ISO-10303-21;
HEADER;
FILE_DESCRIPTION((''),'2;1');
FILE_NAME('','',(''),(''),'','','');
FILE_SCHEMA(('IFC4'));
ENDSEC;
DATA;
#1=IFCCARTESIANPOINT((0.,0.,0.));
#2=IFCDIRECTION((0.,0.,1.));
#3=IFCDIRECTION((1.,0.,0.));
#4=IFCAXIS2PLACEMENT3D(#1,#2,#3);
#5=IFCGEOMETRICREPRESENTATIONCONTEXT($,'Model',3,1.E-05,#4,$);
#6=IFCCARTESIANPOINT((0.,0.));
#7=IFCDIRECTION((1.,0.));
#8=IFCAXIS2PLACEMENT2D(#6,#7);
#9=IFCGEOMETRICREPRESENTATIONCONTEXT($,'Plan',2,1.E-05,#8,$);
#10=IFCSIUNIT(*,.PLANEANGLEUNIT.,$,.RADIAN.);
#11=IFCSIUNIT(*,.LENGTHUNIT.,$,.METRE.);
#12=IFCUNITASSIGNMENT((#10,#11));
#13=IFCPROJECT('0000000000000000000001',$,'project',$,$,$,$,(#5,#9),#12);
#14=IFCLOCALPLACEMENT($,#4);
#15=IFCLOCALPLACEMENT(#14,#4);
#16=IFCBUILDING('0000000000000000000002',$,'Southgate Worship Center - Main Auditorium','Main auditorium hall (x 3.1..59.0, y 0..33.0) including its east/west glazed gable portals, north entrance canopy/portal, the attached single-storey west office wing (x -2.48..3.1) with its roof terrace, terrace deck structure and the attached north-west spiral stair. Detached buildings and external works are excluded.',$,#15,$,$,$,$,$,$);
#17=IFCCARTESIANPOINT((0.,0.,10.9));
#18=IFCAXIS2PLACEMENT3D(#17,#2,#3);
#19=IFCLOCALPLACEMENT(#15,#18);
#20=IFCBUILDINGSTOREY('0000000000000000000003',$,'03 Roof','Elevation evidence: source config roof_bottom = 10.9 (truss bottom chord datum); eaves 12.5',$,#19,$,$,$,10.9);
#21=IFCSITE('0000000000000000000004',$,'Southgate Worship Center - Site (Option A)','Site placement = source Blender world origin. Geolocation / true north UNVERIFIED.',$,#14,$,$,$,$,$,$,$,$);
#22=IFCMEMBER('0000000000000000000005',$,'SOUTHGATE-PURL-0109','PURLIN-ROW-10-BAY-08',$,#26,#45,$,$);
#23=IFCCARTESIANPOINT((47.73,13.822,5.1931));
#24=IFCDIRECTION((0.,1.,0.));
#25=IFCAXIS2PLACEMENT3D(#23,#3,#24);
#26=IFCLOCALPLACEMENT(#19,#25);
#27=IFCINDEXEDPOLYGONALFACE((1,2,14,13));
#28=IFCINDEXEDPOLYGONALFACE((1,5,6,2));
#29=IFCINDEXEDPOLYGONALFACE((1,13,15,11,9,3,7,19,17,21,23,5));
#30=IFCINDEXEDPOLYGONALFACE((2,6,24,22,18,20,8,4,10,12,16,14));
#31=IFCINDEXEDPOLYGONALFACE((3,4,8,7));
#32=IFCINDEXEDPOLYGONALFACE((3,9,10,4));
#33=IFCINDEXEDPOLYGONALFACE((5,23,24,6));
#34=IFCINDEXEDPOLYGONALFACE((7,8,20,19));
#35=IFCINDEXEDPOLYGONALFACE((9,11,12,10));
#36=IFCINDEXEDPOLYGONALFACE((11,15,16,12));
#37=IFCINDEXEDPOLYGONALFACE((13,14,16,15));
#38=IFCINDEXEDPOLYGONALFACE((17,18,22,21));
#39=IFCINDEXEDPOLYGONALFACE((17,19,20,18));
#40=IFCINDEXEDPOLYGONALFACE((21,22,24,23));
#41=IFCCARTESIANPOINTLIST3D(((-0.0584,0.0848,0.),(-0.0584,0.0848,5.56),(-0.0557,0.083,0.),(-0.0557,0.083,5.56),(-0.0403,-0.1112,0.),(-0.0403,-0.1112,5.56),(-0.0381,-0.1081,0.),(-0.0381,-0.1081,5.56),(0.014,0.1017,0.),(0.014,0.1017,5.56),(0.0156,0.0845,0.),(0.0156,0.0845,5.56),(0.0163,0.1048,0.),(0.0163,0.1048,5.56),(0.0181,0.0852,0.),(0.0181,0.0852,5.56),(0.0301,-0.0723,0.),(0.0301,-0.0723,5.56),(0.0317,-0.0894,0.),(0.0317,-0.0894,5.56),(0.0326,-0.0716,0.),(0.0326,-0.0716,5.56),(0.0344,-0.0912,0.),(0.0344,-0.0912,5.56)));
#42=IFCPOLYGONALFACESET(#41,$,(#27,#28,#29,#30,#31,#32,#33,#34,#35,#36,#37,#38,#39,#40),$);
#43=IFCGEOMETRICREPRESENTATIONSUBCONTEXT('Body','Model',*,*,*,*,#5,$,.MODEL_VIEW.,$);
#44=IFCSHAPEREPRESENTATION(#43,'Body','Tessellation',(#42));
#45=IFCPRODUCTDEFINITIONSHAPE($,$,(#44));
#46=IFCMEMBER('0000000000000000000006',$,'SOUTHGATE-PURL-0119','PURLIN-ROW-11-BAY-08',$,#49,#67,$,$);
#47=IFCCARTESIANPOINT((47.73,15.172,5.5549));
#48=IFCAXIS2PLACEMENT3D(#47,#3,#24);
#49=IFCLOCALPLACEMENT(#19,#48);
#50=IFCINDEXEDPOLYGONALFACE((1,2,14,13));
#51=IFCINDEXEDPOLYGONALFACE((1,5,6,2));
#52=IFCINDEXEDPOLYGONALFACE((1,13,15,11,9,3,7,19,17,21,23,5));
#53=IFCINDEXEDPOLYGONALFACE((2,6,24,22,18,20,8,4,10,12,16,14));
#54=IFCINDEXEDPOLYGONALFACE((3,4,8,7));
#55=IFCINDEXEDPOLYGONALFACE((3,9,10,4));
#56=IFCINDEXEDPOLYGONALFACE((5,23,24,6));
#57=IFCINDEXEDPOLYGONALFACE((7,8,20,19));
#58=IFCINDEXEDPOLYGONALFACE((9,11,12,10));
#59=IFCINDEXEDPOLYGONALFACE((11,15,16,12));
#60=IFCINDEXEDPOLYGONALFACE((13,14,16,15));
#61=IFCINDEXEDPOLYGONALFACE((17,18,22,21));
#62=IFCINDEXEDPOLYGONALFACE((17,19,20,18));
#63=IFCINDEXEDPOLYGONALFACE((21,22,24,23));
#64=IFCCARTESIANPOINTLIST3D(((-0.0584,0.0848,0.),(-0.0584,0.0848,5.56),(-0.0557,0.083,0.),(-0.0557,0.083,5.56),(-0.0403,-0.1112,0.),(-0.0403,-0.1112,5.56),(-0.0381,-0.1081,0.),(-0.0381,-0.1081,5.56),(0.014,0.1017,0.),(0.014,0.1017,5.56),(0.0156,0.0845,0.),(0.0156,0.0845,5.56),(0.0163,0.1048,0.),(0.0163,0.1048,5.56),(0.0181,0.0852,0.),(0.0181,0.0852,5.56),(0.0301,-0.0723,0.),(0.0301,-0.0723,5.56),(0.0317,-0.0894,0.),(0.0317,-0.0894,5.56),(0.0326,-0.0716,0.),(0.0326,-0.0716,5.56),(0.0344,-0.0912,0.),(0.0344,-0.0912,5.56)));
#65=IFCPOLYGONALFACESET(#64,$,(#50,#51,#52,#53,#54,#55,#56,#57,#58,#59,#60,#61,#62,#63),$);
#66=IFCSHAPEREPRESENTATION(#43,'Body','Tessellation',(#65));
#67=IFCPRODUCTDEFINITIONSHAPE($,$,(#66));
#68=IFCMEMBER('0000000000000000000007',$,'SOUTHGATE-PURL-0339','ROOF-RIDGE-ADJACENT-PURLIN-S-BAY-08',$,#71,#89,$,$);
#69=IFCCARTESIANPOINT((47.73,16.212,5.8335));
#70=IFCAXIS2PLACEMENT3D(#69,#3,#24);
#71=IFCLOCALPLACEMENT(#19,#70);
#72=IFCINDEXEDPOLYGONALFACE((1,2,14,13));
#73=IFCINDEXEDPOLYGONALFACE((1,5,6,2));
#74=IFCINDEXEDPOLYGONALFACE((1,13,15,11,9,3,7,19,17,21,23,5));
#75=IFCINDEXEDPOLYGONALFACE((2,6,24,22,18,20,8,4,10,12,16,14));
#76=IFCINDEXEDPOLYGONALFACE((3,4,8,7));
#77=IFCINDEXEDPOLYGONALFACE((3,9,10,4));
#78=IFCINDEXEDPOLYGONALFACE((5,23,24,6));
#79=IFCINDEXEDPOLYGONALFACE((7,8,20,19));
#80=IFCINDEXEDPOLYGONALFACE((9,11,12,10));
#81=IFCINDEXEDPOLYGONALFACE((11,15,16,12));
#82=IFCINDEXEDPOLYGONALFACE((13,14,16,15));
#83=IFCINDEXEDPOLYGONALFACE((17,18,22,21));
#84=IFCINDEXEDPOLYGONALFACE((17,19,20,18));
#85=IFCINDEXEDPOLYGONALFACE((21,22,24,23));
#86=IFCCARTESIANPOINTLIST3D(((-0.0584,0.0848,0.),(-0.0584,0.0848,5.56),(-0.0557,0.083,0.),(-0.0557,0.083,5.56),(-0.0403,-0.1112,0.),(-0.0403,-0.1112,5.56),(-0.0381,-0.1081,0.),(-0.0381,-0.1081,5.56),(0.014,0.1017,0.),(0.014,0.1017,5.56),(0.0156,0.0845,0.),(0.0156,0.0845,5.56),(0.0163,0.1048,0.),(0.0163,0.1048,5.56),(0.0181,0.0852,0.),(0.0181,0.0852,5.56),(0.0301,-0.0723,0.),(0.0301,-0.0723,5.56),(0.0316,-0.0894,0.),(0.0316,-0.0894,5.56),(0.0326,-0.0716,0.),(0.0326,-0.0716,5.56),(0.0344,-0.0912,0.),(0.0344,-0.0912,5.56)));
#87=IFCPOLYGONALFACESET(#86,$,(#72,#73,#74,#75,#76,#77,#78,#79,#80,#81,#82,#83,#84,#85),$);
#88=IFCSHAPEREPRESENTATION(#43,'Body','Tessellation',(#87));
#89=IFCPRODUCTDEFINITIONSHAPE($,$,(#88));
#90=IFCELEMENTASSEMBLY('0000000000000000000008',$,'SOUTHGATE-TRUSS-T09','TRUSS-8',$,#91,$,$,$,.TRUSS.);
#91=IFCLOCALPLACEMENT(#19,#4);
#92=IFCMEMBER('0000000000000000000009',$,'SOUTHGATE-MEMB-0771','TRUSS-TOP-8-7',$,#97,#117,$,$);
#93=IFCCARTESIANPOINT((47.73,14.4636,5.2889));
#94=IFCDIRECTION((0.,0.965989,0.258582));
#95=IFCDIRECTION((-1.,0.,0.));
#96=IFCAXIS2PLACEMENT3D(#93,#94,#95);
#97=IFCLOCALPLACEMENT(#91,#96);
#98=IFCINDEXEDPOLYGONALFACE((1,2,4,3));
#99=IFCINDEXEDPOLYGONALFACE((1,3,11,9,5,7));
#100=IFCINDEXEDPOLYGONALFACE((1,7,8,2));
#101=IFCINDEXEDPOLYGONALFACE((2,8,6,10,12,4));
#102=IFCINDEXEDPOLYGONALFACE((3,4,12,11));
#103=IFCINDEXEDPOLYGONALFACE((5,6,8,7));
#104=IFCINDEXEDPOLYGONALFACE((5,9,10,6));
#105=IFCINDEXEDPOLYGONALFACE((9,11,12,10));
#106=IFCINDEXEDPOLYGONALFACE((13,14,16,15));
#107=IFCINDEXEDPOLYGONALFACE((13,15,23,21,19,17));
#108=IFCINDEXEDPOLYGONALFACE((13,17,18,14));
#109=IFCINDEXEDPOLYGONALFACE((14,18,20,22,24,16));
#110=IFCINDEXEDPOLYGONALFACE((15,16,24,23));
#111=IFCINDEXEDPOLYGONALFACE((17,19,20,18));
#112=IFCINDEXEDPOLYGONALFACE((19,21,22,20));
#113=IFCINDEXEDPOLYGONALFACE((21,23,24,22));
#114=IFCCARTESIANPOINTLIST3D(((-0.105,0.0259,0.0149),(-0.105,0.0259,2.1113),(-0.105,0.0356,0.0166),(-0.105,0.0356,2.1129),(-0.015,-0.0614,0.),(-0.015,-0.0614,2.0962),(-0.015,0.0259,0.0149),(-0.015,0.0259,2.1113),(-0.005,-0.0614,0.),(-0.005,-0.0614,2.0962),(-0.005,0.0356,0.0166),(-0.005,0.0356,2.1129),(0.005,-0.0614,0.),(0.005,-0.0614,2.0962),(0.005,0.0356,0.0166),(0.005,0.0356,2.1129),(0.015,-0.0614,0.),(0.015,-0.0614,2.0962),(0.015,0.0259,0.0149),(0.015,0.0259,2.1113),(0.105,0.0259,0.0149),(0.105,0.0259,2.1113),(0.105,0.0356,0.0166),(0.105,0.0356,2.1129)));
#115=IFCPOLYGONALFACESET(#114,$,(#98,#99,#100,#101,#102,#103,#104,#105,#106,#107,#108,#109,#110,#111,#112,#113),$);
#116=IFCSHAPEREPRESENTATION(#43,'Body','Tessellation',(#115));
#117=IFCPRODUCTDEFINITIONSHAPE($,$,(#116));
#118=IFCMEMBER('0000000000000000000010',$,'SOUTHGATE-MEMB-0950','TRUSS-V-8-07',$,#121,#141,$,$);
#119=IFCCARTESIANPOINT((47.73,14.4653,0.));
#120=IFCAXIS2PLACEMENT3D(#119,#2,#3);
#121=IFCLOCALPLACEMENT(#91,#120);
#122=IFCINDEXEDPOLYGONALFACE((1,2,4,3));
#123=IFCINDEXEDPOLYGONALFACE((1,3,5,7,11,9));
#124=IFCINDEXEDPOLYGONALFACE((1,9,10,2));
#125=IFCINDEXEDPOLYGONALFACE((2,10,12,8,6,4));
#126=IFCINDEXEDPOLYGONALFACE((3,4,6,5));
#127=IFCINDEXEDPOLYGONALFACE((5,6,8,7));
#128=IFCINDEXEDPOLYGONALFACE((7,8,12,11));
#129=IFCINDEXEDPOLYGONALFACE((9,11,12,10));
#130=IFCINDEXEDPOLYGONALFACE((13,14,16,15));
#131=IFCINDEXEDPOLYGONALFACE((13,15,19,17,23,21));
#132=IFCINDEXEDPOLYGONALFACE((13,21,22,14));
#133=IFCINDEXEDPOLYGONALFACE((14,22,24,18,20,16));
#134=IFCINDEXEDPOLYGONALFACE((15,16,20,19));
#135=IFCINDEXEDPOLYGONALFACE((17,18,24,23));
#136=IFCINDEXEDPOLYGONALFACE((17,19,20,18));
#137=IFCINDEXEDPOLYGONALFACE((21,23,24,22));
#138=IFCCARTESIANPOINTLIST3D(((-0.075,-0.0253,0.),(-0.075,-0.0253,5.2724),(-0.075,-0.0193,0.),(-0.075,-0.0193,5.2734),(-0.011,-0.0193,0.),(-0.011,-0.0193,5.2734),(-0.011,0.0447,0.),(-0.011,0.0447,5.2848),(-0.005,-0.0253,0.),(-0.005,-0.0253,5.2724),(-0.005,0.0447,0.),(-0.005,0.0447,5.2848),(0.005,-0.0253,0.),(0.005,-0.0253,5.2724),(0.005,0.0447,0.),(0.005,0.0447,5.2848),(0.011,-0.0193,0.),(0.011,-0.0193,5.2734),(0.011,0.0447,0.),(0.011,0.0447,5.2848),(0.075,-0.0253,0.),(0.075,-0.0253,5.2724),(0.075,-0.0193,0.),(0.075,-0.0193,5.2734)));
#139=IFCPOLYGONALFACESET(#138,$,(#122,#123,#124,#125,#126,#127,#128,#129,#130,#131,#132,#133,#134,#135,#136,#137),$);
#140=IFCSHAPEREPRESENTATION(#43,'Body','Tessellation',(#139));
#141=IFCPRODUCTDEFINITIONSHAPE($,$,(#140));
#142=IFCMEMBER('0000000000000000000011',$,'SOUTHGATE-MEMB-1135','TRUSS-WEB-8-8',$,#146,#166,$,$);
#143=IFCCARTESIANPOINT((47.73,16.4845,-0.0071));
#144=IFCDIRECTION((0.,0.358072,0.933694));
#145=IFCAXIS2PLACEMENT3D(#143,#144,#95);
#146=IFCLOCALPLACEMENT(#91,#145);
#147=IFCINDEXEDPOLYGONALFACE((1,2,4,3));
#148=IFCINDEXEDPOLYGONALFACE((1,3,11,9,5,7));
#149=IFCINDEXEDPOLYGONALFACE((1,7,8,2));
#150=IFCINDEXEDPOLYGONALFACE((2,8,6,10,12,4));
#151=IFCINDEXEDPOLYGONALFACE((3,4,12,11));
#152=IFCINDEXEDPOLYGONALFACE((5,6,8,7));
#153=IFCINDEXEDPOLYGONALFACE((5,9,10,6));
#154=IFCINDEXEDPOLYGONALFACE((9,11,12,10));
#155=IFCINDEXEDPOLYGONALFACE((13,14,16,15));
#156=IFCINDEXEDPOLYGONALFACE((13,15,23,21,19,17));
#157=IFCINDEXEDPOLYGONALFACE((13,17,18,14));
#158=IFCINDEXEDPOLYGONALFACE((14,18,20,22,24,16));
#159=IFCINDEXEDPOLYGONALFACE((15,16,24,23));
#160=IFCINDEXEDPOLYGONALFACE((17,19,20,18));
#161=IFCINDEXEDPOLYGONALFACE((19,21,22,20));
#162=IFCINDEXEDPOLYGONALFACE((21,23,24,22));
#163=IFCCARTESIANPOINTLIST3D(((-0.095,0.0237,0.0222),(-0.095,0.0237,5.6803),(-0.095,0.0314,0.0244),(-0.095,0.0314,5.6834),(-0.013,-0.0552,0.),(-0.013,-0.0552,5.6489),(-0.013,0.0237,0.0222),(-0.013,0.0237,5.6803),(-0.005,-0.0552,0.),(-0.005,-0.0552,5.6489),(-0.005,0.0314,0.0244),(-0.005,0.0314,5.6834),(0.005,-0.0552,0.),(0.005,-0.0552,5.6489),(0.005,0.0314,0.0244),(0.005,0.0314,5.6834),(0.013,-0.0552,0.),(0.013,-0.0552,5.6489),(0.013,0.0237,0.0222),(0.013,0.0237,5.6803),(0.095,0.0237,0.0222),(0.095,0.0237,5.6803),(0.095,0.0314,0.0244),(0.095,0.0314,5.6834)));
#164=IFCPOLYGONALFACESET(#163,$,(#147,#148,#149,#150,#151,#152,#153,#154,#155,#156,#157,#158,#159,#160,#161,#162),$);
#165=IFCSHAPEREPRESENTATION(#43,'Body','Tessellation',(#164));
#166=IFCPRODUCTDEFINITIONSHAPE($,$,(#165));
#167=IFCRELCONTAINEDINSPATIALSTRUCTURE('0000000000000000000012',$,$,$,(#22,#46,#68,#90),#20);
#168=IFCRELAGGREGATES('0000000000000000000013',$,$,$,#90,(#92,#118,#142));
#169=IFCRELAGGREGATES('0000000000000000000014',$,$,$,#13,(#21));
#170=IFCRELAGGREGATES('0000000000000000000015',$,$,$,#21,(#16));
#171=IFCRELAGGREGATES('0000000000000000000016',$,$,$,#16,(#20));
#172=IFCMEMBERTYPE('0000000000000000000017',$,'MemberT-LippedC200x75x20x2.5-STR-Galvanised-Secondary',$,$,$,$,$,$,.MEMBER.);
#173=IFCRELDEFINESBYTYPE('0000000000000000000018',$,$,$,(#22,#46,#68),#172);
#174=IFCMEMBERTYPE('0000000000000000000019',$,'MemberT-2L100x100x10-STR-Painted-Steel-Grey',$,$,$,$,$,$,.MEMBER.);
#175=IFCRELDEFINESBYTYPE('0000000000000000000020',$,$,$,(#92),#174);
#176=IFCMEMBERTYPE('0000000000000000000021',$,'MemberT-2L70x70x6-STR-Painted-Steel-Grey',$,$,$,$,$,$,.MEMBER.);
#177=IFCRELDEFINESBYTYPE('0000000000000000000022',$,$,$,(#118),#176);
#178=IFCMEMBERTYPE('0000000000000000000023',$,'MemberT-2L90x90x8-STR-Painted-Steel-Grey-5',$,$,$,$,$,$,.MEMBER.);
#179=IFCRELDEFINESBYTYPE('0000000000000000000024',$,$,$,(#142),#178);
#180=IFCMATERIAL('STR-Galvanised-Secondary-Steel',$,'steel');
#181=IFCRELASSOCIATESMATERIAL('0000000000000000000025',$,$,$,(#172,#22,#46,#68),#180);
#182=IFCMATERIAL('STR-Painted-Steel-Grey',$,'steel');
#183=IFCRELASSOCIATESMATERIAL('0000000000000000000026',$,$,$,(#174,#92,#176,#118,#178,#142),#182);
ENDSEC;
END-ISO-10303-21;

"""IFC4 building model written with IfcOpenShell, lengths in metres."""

from ifc_helpers import new_model, si_unit, frame, origin_with_axes, origin_2d_with_axis, place, context, subcontext, project, spatial, indexed_curve, outline, composite_profile, extrude, clip, halfspace, material, material_profile, profile_set, profile_usage, type_object, element, aggregate, save


model = new_model("IFC4")

# Units and contexts
model_context = context("Model", 3, precision=1e-05, world=origin_with_axes())
plan_context = context("Plan", 2, precision=1e-05, world=origin_2d_with_axis())
body_context = subcontext(model_context, "Body", "Model", "MODEL_VIEW")
ifc_project = project(units=[si_unit("PLANEANGLEUNIT", "RADIAN"), si_unit("LENGTHUNIT", "METRE")], contexts=[model_context, plan_context])

# Site, building, storey
site_placement = place(None, origin_with_axes())
site = spatial("IfcSite", under=ifc_project, at=site_placement, Name="Southgate Worship Center - Site (Option A)", Description="Site placement = source Blender world origin. Geolocation / true north UNVERIFIED.")
building_placement = place(site_placement, origin_with_axes())
building = spatial("IfcBuilding", under=site, at=building_placement, Name="Southgate Worship Center - Main Auditorium", Description="Main auditorium hall (x 3.1..59.0, y 0..33.0) including its east/west glazed gable portals, north entrance canopy/portal, the attached single-storey west office wing (x -2.48..3.1) with its roof terrace, terrace deck structure and the attached north-west spiral stair. Detached buildings and external works are excluded.")
storey_placement = place(building_placement, frame((0.0, 0.0, 10.9), z_axis=(0.0, 0.0, 1.0), x_axis=(1.0, 0.0, 0.0)))
storey = spatial("IfcBuildingStorey", under=building, at=storey_placement, Name="03 Roof", Description="Elevation evidence: source config roof_bottom = 10.9 (truss bottom chord datum); eaves 12.5", Elevation=10.9)

# Members
ifc_material_1 = material(Name="STR-Galvanised-Secondary-Steel", Category="steel")
ifc_material_profile_1 = material_profile(ifc_material_1, outline(indexed_curve([(0.014, 0.1017), (0.0156, 0.0845), (0.0181, 0.0852), (0.0163, 0.1048), (-0.0584, 0.0848), (-0.0403, -0.1112), (0.0344, -0.0912), (0.0326, -0.0716), (0.0301, -0.0723), (0.0316, -0.0894), (-0.0381, -0.1081), (-0.0557, 0.083), (0.014, 0.1017)], self_intersect=False)))
ifc_profile_set_1 = profile_set([ifc_material_profile_1], Name="MemberT-LippedC200x75x20x2.5-STR-Galvanised-Secondary")
ifc_profile_usage_1 = profile_usage(ifc_profile_set_1)
member_type_1 = type_object("IfcMemberType", Name="MemberT-LippedC200x75x20x2.5-STR-Galvanised-Secondary", PredefinedType="MEMBER", material=ifc_profile_set_1)
for number, where, z_axis, x_axis, name, description in (
    (1, (47.73, 13.822, 5.1931), (1.0, 0.0, 0.0), (0.0, 1.0, 0.0), "SOUTHGATE-PURL-0109", "PURLIN-ROW-10-BAY-08"),
    (2, (47.73, 15.172, 5.5549), (1.0, 0.0, 0.0), (0.0, 1.0, 0.0), "SOUTHGATE-PURL-0119", "PURLIN-ROW-11-BAY-08"),
    (3, (47.73, 16.212, 5.8335), (1.0, 0.0, 0.0), (0.0, 1.0, 0.0), "SOUTHGATE-PURL-0339", "ROOF-RIDGE-ADJACENT-PURLIN-S-BAY-08"),
):
    element("IfcMember", number, at=place(storey_placement, frame(where, z_axis=z_axis, x_axis=x_axis)), inside=storey, type_object=member_type_1, material=ifc_profile_usage_1, Name=name, Description=description, context=body_context, shape_type="SweptSolid", body=[
        extrude(outline(indexed_curve([(0.014, 0.1017), (0.0156, 0.0845), (0.0181, 0.0852), (0.0163, 0.1048), (-0.0584, 0.0848), (-0.0403, -0.1112), (0.0344, -0.0912), (0.0326, -0.0716), (0.0301, -0.0723), (0.0316, -0.0894), (-0.0381, -0.1081), (-0.0557, 0.083), (0.014, 0.1017)], self_intersect=False)), origin_with_axes(), (0.0, 0.0, 1.0), 5.56),
    ])

# Element assembly, members
assembly_1_placement = place(storey_placement, origin_with_axes())
assembly_1 = element("IfcElementAssembly", 4, at=assembly_1_placement, inside=storey, Name="SOUTHGATE-TRUSS-T09", Description="TRUSS-8", PredefinedType="TRUSS")
ifc_material_2 = material(Name="STR-Painted-Steel-Grey", Category="steel")
ifc_material_profile_2 = material_profile(ifc_material_2, composite_profile([outline(indexed_curve([(0.005, 0.0356), (0.005, -0.0614), (0.015, -0.0614), (0.015, 0.0259), (0.105, 0.0259), (0.105, 0.0356), (0.005, 0.0356)], self_intersect=False)), outline(indexed_curve([(-0.105, 0.0356), (-0.105, 0.0259), (-0.015, 0.0259), (-0.015, -0.0614), (-0.005, -0.0614), (-0.005, 0.0356), (-0.105, 0.0356)], self_intersect=False))]))
ifc_profile_set_2 = profile_set([ifc_material_profile_2], Name="MemberT-2L100x100x10-STR-Painted-Steel-Grey")
ifc_profile_usage_2 = profile_usage(ifc_profile_set_2)
member_type_2 = type_object("IfcMemberType", Name="MemberT-2L100x100x10-STR-Painted-Steel-Grey", PredefinedType="MEMBER", material=ifc_profile_set_2)
member_1_placement = place(assembly_1_placement, frame((47.73, 14.4636, 5.2889), z_axis=(0.0, 0.965989, 0.258582), x_axis=(-1.0, 0.0, 0.0)))
member_1 = element("IfcMember", 5, at=member_1_placement, type_object=member_type_2, material=ifc_profile_usage_2, Name="SOUTHGATE-MEMB-0771", Description="TRUSS-TOP-8-7", context=body_context, shape_type="Clipping", body=[
    clip(clip(extrude(composite_profile([outline(indexed_curve([(0.005, 0.0356), (0.005, -0.0614), (0.015, -0.0614), (0.015, 0.0259), (0.105, 0.0259), (0.105, 0.0356), (0.005, 0.0356)], self_intersect=False)), outline(indexed_curve([(-0.105, 0.0356), (-0.105, 0.0259), (-0.015, 0.0259), (-0.015, -0.0614), (-0.005, -0.0614), (-0.005, 0.0356), (-0.105, 0.0356)], self_intersect=False))]), origin_with_axes(), (0.0, 0.0, 1.0), 2.113), halfspace(frame((0.0417, 0.0, 0.0105), z_axis=(0.000001, 0.168604, -0.985684), x_axis=(-1.0, 0.000004, 0.0)), False)), halfspace(frame((0.0417, 0.0, 2.1068), z_axis=(-0.000015, -0.170126, 0.985422), x_axis=(1.0, -0.000089, 0.0)), False)),
])
ifc_material_profile_3 = material_profile(ifc_material_2, composite_profile([outline(indexed_curve([(-0.075, -0.0253), (-0.005, -0.0253), (-0.005, 0.0447), (-0.011, 0.0447), (-0.011, -0.0193), (-0.075, -0.0193), (-0.075, -0.0253)], self_intersect=False)), outline(indexed_curve([(0.011, 0.0447), (0.005, 0.0447), (0.005, -0.0253), (0.075, -0.0253), (0.075, -0.0193), (0.011, -0.0193), (0.011, 0.0447)], self_intersect=False))]))
ifc_profile_set_3 = profile_set([ifc_material_profile_3], Name="MemberT-2L70x70x6-STR-Painted-Steel-Grey")
ifc_profile_usage_3 = profile_usage(ifc_profile_set_3)
member_type_3 = type_object("IfcMemberType", Name="MemberT-2L70x70x6-STR-Painted-Steel-Grey", PredefinedType="MEMBER", material=ifc_profile_set_3)
member_2_placement = place(assembly_1_placement, frame((47.73, 14.4653, 0.0), z_axis=(0.0, 0.0, 1.0), x_axis=(1.0, 0.0, 0.0)))
member_2 = element("IfcMember", 6, at=member_2_placement, type_object=member_type_3, material=ifc_profile_usage_3, Name="SOUTHGATE-MEMB-0950", Description="TRUSS-V-8-07", context=body_context, shape_type="Clipping", body=[
    clip(extrude(composite_profile([outline(indexed_curve([(-0.075, -0.0253), (-0.005, -0.0253), (-0.005, 0.0447), (-0.011, 0.0447), (-0.011, -0.0193), (-0.075, -0.0193), (-0.075, -0.0253)], self_intersect=False)), outline(indexed_curve([(0.011, 0.0447), (0.005, 0.0447), (0.005, -0.0253), (0.075, -0.0253), (0.075, -0.0193), (0.011, -0.0193), (0.011, 0.0447)], self_intersect=False))]), origin_with_axes(), (0.0, 0.0, 1.0), 5.2848), halfspace(frame((-0.0303, 0.0, 5.2769), z_axis=(0.0, -0.174345, 0.984685), x_axis=(1.0, 0.000001, 0.0)), False)),
])
ifc_material_profile_4 = material_profile(ifc_material_2, composite_profile([outline(indexed_curve([(0.005, 0.0314), (0.005, -0.0552), (0.013, -0.0552), (0.013, 0.0237), (0.095, 0.0237), (0.095, 0.0314), (0.005, 0.0314)], self_intersect=False)), outline(indexed_curve([(-0.095, 0.0314), (-0.095, 0.0237), (-0.013, 0.0237), (-0.013, -0.0552), (-0.005, -0.0552), (-0.005, 0.0314), (-0.095, 0.0314)], self_intersect=False))]))
ifc_profile_set_4 = profile_set([ifc_material_profile_4], Name="MemberT-2L90x90x8-STR-Painted-Steel-Grey-5")
ifc_profile_usage_4 = profile_usage(ifc_profile_set_4)
member_type_4 = type_object("IfcMemberType", Name="MemberT-2L90x90x8-STR-Painted-Steel-Grey-5", PredefinedType="MEMBER", material=ifc_profile_set_4)
member_3_placement = place(assembly_1_placement, frame((47.73, 16.4845, -0.0071), z_axis=(0.0, 0.358072, 0.933694), x_axis=(-1.0, 0.0, 0.0)))
member_3 = element("IfcMember", 7, at=member_3_placement, type_object=member_type_4, material=ifc_profile_usage_4, Name="SOUTHGATE-MEMB-1135", Description="TRUSS-WEB-8-8", context=body_context, shape_type="Clipping", body=[
    clip(clip(extrude(composite_profile([outline(indexed_curve([(0.005, 0.0314), (0.005, -0.0552), (0.013, -0.0552), (0.013, 0.0237), (0.095, 0.0237), (0.095, 0.0314), (0.005, 0.0314)], self_intersect=False)), outline(indexed_curve([(-0.095, 0.0314), (-0.095, 0.0237), (-0.013, 0.0237), (-0.013, -0.0552), (-0.005, -0.0552), (-0.005, 0.0314), (-0.095, 0.0314)], self_intersect=False))]), origin_with_axes(), (0.0, 0.0, 1.0), 5.684), halfspace(frame((0.0377, 0.0, 0.0155), z_axis=(0.0, 0.271049, -0.962565), x_axis=(-1.0, -0.000002, 0.0)), False)), halfspace(frame((0.0377, 0.0, 5.6708), z_axis=(0.0, -0.369979, 0.92904), x_axis=(1.0, 0.0, 0.0)), False)),
])

aggregate(assembly_1, [member_1, member_2, member_3])

save(model, "model.ifc")
